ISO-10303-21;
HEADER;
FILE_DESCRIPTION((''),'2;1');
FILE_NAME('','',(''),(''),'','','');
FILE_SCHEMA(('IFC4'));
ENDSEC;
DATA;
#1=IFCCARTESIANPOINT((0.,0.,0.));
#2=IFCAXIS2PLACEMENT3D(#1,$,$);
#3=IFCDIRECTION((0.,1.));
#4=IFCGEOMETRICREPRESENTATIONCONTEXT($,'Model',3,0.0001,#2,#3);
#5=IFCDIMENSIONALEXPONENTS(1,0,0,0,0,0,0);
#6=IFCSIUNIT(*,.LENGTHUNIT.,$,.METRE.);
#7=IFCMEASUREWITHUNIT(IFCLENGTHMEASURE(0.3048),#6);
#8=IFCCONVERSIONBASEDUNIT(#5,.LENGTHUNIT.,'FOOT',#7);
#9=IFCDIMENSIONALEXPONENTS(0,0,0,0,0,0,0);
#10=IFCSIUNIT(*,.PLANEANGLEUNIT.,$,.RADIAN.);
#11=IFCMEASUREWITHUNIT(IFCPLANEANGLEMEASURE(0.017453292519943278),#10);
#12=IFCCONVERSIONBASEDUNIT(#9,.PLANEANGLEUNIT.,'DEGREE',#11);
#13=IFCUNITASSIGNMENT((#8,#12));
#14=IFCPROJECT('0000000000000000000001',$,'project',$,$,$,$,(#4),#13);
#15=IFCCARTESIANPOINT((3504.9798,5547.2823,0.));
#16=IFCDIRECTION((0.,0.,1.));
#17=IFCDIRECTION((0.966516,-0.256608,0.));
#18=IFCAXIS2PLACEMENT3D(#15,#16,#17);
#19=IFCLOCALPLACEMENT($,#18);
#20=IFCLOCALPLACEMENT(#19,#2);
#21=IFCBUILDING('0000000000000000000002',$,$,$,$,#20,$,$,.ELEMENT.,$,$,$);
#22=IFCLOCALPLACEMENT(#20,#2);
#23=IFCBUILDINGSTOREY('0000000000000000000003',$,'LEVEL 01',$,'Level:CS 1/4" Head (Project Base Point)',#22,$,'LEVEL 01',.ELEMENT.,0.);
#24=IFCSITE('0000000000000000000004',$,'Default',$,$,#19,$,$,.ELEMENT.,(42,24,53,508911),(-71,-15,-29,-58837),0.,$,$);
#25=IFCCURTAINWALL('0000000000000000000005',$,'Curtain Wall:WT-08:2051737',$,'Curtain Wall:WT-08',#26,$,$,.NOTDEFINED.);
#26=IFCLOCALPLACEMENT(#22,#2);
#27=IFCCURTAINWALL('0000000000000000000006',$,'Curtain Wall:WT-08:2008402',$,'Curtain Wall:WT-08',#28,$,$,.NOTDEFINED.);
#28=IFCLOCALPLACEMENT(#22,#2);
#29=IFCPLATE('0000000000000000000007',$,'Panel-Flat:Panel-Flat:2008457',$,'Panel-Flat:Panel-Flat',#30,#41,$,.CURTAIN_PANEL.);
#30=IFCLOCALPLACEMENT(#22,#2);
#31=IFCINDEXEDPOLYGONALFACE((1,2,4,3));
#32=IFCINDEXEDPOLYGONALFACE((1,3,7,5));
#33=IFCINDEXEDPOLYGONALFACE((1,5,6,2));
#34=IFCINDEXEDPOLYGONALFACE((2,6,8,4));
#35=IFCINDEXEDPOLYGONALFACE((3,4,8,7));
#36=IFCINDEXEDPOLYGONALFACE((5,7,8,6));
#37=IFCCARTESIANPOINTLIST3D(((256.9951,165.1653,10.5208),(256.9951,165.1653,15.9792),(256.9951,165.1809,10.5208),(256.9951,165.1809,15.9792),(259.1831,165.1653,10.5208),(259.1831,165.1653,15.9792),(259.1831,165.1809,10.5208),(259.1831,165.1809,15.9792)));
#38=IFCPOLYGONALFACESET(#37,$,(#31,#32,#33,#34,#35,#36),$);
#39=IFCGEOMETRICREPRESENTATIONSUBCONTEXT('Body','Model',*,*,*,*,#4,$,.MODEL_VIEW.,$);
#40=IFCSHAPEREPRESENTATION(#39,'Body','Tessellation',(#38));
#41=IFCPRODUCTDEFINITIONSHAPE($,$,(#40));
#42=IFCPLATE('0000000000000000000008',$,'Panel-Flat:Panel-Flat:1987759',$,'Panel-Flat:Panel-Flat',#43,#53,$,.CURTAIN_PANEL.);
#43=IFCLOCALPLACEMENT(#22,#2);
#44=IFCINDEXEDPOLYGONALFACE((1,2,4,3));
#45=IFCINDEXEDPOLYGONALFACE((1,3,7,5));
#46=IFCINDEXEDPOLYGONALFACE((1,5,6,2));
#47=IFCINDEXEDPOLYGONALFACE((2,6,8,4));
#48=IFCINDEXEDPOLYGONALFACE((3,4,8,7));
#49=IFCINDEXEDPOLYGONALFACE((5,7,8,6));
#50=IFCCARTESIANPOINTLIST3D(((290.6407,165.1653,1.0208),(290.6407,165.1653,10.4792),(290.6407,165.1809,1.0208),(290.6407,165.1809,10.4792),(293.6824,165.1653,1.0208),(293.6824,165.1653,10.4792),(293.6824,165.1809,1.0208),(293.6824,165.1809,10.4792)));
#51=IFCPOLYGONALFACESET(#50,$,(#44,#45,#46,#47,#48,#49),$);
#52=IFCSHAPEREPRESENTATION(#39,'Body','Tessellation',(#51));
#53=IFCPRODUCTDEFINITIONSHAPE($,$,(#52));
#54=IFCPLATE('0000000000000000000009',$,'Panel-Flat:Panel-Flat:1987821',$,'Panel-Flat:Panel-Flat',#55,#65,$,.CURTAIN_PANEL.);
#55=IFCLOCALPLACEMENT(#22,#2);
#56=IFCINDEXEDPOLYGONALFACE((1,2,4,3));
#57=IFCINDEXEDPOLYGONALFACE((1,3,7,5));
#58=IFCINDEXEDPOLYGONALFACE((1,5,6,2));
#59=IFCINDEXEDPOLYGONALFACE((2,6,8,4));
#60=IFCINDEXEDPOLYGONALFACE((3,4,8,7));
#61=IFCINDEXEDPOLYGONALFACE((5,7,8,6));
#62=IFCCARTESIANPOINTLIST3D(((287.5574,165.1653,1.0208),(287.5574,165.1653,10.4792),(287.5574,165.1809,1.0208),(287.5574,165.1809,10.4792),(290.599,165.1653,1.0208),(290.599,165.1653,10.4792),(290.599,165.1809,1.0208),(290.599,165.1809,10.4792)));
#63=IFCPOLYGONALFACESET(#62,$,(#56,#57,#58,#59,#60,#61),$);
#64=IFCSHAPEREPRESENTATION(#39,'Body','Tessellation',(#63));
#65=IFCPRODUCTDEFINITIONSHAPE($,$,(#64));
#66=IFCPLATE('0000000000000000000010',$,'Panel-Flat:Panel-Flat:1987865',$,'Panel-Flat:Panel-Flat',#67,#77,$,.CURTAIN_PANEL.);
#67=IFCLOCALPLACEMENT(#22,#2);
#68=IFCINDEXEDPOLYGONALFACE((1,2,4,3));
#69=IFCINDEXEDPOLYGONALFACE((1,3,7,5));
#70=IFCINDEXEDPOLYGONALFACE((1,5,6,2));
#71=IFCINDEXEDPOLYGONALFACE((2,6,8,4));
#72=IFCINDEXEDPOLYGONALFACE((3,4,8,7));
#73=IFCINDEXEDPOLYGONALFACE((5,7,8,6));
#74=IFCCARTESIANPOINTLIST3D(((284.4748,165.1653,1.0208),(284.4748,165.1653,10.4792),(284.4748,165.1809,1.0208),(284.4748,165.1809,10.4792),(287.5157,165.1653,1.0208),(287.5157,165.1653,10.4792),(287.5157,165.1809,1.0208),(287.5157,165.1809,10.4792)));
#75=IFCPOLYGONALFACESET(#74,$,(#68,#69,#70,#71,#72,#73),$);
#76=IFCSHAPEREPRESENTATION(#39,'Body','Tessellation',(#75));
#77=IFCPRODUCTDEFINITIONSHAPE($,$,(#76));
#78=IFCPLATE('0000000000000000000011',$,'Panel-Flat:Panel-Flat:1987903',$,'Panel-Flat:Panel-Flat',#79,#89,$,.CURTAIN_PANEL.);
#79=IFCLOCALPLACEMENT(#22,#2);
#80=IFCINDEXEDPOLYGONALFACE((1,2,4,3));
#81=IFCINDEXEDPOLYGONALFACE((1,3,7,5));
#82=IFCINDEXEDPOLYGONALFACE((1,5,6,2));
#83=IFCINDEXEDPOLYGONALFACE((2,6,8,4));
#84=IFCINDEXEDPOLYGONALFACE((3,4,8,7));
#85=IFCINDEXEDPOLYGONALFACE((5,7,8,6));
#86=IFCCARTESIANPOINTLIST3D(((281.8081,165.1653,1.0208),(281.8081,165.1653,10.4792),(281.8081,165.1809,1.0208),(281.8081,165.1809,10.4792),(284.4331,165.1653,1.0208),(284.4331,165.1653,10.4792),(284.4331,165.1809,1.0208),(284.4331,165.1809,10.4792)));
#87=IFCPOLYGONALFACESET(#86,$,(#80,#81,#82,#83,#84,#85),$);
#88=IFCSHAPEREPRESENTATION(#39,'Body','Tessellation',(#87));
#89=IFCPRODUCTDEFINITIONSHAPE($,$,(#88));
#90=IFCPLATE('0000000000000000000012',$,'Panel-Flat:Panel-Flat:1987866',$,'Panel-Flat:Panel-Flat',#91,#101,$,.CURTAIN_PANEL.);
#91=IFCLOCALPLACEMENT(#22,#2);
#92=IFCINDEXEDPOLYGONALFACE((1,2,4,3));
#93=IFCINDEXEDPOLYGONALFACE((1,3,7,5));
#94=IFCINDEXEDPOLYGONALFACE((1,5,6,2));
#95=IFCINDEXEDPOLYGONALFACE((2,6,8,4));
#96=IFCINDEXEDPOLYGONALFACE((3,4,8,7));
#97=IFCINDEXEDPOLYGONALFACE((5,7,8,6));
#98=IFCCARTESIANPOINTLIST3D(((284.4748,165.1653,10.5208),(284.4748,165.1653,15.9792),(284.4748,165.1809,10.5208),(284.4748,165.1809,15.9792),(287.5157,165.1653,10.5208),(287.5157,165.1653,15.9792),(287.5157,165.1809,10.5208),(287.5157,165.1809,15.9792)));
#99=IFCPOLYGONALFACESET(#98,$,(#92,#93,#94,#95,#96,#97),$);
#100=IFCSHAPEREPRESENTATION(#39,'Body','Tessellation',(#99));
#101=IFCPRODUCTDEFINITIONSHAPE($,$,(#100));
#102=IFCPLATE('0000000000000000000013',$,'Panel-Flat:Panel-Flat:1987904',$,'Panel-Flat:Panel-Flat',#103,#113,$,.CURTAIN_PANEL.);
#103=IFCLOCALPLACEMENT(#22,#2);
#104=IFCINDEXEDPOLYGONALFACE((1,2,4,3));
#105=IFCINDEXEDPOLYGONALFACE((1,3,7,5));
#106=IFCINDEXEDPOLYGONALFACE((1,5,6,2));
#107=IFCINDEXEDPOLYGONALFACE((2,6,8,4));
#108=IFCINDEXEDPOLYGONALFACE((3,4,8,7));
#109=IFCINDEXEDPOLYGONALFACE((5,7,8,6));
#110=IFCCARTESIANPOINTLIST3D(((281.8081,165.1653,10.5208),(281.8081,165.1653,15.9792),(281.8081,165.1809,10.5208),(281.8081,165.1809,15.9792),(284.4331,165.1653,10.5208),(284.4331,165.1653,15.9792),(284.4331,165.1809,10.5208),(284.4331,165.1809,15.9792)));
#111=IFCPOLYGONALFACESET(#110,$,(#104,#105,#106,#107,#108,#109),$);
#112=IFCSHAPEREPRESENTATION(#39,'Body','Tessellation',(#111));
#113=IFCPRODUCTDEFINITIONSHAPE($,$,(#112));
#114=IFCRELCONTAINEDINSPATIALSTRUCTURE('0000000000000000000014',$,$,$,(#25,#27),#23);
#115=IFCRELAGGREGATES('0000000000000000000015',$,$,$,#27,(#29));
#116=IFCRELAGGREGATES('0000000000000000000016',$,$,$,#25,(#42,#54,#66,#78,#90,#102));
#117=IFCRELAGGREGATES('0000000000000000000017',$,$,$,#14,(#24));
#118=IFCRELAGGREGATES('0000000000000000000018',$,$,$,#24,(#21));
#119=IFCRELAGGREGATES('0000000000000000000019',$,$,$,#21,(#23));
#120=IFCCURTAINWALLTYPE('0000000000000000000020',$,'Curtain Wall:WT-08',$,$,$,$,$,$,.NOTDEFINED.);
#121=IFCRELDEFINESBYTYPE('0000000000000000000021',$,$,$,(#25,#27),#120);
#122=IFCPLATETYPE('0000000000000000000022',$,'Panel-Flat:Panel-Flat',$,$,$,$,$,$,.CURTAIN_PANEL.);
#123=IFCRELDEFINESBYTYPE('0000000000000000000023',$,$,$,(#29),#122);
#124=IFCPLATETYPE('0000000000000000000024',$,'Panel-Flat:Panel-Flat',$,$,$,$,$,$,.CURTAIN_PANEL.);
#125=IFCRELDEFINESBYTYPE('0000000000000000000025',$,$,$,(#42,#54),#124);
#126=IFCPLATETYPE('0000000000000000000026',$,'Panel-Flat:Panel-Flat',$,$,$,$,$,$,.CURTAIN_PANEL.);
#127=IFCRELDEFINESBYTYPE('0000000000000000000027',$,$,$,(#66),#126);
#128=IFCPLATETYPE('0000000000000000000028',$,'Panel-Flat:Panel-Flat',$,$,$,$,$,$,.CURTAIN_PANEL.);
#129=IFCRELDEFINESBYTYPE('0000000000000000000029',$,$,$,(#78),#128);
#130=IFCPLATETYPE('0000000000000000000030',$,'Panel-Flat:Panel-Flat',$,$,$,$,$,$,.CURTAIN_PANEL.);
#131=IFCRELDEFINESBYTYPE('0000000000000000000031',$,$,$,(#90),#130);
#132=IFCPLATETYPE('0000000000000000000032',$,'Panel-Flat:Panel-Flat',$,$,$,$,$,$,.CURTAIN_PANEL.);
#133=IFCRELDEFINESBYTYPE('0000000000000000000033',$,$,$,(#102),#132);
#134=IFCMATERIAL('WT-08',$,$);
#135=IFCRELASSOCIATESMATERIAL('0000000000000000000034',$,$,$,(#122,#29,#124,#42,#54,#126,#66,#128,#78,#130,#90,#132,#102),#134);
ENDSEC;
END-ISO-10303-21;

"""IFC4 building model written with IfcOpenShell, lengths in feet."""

from ifc_helpers import new_model, entity, si_unit, converted_unit, direction, frame, origin, place, context, subcontext, project, spatial, indexed_curve, outline, extrude, source, transform, mapped, material, type_object, type_shapes, element, aggregate, save


model = new_model("IFC4")

# Units and contexts
model_context = context("Model", 3, precision=0.0001, world=origin(), true_north=direction((0.0, 1.0)))
body_context = subcontext(model_context, "Body", "Model", "MODEL_VIEW")
ifc_project = project(units=[converted_unit("LENGTHUNIT", "FOOT", entity("IfcLengthMeasure", 0.3048), si_unit("LENGTHUNIT", "METRE"), dimensions=[1, 0, 0, 0, 0, 0, 0]), converted_unit("PLANEANGLEUNIT", "DEGREE", entity("IfcPlaneAngleMeasure", 0.017453292519943278), si_unit("PLANEANGLEUNIT", "RADIAN"), dimensions=[0, 0, 0, 0, 0, 0, 0])], contexts=[model_context])

# Site, building, storey
site_placement = place(None, frame((3504.9798, 5547.2823, 0.0), z_axis=(0.0, 0.0, 1.0), x_axis=(0.966516, -0.256608, 0.0)))
site = spatial("IfcSite", under=ifc_project, at=site_placement, Name="Default", CompositionType="ELEMENT", RefLatitude=(42, 24, 53, 508911), RefLongitude=(-71, -15, -29, -58837), RefElevation=0.0)
building_placement = place(site_placement, origin())
building = spatial("IfcBuilding", under=site, at=building_placement, CompositionType="ELEMENT")
storey_placement = place(building_placement, origin())
storey = spatial("IfcBuildingStorey", under=building, at=storey_placement, Name="LEVEL 01", ObjectType="Level:CS 1/4\" Head (Project Base Point)", LongName="LEVEL 01", CompositionType="ELEMENT", Elevation=0.0)

# Curtain wall
curtain_wall_type_1 = type_object("IfcCurtainWallType", Name="Curtain Wall:WT-08", PredefinedType="NOTDEFINED")
curtain_wall_1_placement = place(storey_placement, origin())
curtain_wall_1 = element("IfcCurtainWall", 1, at=curtain_wall_1_placement, inside=storey, type_object=curtain_wall_type_1, Name="Curtain Wall:WT-08:2051737", ObjectType="Curtain Wall:WT-08", PredefinedType="NOTDEFINED")
ifc_material_1 = material(Name="WT-08")

# Curtain wall, plate
curtain_wall_2_placement = place(storey_placement, origin())
curtain_wall_2 = element("IfcCurtainWall", 2, at=curtain_wall_2_placement, inside=storey, type_object=curtain_wall_type_1, Name="Curtain Wall:WT-08:2008402", ObjectType="Curtain Wall:WT-08", PredefinedType="NOTDEFINED")
plate_type_1 = type_object("IfcPlateType", Name="Panel-Flat:Panel-Flat", PredefinedType="CURTAIN_PANEL", material=ifc_material_1)
shared_shape_1 = source(origin(), body_context, "Body", "SweptSolid", [
    extrude(outline(indexed_curve([(-0.0078, -1.094), (0.0078, -1.094), (0.0078, 1.094), (-0.0078, 1.094), (-0.0078, -1.094)], self_intersect=False)), frame((0.0, -0.0078, 0.0208), z_axis=(0.0, 0.0, 1.0), x_axis=(0.0, -1.0, 0.0)), (0.0, 0.0, 1.0), 5.4583),
])
type_shapes(plate_type_1, [shared_shape_1])
plate_1_placement = place(curtain_wall_2_placement, frame((258.0891, 165.1653, 10.5), z_axis=(0.0, 0.0, 1.0), x_axis=(-1.0, 0.0, 0.0)))
plate_1 = element("IfcPlate", 3, at=plate_1_placement, type_object=plate_type_1, material=ifc_material_1, Name="Panel-Flat:Panel-Flat:2008457", ObjectType="Panel-Flat:Panel-Flat", PredefinedType="CURTAIN_PANEL", context=body_context, shape_type="MappedRepresentation", body=[
    mapped(shared_shape_1, transform((0.0, 0.0, 0.0), scale=1.0)),
])
aggregate(curtain_wall_2, [plate_1])

# Plates
plate_type_2 = type_object("IfcPlateType", Name="Panel-Flat:Panel-Flat", PredefinedType="CURTAIN_PANEL", material=ifc_material_1)
shared_shape_2 = source(origin(), body_context, "Body", "SweptSolid", [
    extrude(outline(indexed_curve([(-0.0078, -1.5208), (0.0078, -1.5208), (0.0078, 1.5208), (-0.0078, 1.5208), (-0.0078, -1.5208)], self_intersect=False)), frame((0.0, -0.0078, 0.0208), z_axis=(0.0, 0.0, 1.0), x_axis=(0.0, -1.0, 0.0)), (0.0, 0.0, 1.0), 9.4583),
])
type_shapes(plate_type_2, [shared_shape_2])
plate_2_placement = place(curtain_wall_1_placement, frame((292.1615, 165.1653, 1.0), z_axis=(0.0, 0.0, 1.0), x_axis=(-1.0, 0.0, 0.0)))
plate_2 = element("IfcPlate", 4, at=plate_2_placement, type_object=plate_type_2, material=ifc_material_1, Name="Panel-Flat:Panel-Flat:1987759", ObjectType="Panel-Flat:Panel-Flat", PredefinedType="CURTAIN_PANEL", context=body_context, shape_type="MappedRepresentation", body=[
    mapped(shared_shape_2, transform((0.0, 0.0, 0.0), scale=1.0)),
])
plate_3_placement = place(curtain_wall_1_placement, frame((289.0782, 165.1653, 1.0), z_axis=(0.0, 0.0, 1.0), x_axis=(-1.0, 0.0, 0.0)))
plate_3 = element("IfcPlate", 5, at=plate_3_placement, type_object=plate_type_2, material=ifc_material_1, Name="Panel-Flat:Panel-Flat:1987821", ObjectType="Panel-Flat:Panel-Flat", PredefinedType="CURTAIN_PANEL", context=body_context, shape_type="MappedRepresentation", body=[
    mapped(shared_shape_2, transform((0.0, 0.0, 0.0), scale=1.0)),
])
plate_type_3 = type_object("IfcPlateType", Name="Panel-Flat:Panel-Flat", PredefinedType="CURTAIN_PANEL", material=ifc_material_1)
shared_shape_3 = source(origin(), body_context, "Body", "SweptSolid", [
    extrude(outline(indexed_curve([(-0.0078, -1.5205), (0.0078, -1.5205), (0.0078, 1.5205), (-0.0078, 1.5205), (-0.0078, -1.5205)], self_intersect=False)), frame((0.0, -0.0078, 0.0208), z_axis=(0.0, 0.0, 1.0), x_axis=(0.0, -1.0, 0.0)), (0.0, 0.0, 1.0), 9.4583),
])
type_shapes(plate_type_3, [shared_shape_3])
plate_4_placement = place(curtain_wall_1_placement, frame((285.9952, 165.1653, 1.0), z_axis=(0.0, 0.0, 1.0), x_axis=(-1.0, 0.0, 0.0)))
plate_4 = element("IfcPlate", 6, at=plate_4_placement, type_object=plate_type_3, material=ifc_material_1, Name="Panel-Flat:Panel-Flat:1987865", ObjectType="Panel-Flat:Panel-Flat", PredefinedType="CURTAIN_PANEL", context=body_context, shape_type="MappedRepresentation", body=[
    mapped(shared_shape_3, transform((0.0, 0.0, 0.0), scale=1.0)),
])
plate_type_4 = type_object("IfcPlateType", Name="Panel-Flat:Panel-Flat", PredefinedType="CURTAIN_PANEL", material=ifc_material_1)
shared_shape_4 = source(origin(), body_context, "Body", "SweptSolid", [
    extrude(outline(indexed_curve([(-0.0078, -1.3125), (0.0078, -1.3125), (0.0078, 1.3125), (-0.0078, 1.3125), (-0.0078, -1.3125)], self_intersect=False)), frame((0.0, -0.0078, 0.0208), z_axis=(0.0, 0.0, 1.0), x_axis=(0.0, -1.0, 0.0)), (0.0, 0.0, 1.0), 9.4583),
])
type_shapes(plate_type_4, [shared_shape_4])
plate_5_placement = place(curtain_wall_1_placement, frame((283.1206, 165.1653, 1.0), z_axis=(0.0, 0.0, 1.0), x_axis=(-1.0, 0.0, 0.0)))
plate_5 = element("IfcPlate", 7, at=plate_5_placement, type_object=plate_type_4, material=ifc_material_1, Name="Panel-Flat:Panel-Flat:1987903", ObjectType="Panel-Flat:Panel-Flat", PredefinedType="CURTAIN_PANEL", context=body_context, shape_type="MappedRepresentation", body=[
    mapped(shared_shape_4, transform((0.0, 0.0, 0.0), scale=1.0)),
])
plate_type_5 = type_object("IfcPlateType", Name="Panel-Flat:Panel-Flat", PredefinedType="CURTAIN_PANEL", material=ifc_material_1)
shared_shape_5 = source(origin(), body_context, "Body", "SweptSolid", [
    extrude(outline(indexed_curve([(-0.0078, -1.5205), (0.0078, -1.5205), (0.0078, 1.5205), (-0.0078, 1.5205), (-0.0078, -1.5205)], self_intersect=False)), frame((0.0, -0.0078, 0.0208), z_axis=(0.0, 0.0, 1.0), x_axis=(0.0, -1.0, 0.0)), (0.0, 0.0, 1.0), 5.4583),
])
type_shapes(plate_type_5, [shared_shape_5])
plate_6_placement = place(curtain_wall_1_placement, frame((285.9952, 165.1653, 10.5), z_axis=(0.0, 0.0, 1.0), x_axis=(-1.0, 0.0, 0.0)))
plate_6 = element("IfcPlate", 8, at=plate_6_placement, type_object=plate_type_5, material=ifc_material_1, Name="Panel-Flat:Panel-Flat:1987866", ObjectType="Panel-Flat:Panel-Flat", PredefinedType="CURTAIN_PANEL", context=body_context, shape_type="MappedRepresentation", body=[
    mapped(shared_shape_5, transform((0.0, 0.0, 0.0), scale=1.0)),
])
plate_type_6 = type_object("IfcPlateType", Name="Panel-Flat:Panel-Flat", PredefinedType="CURTAIN_PANEL", material=ifc_material_1)
shared_shape_6 = source(origin(), body_context, "Body", "SweptSolid", [
    extrude(outline(indexed_curve([(-0.0078, -1.3125), (0.0078, -1.3125), (0.0078, 1.3125), (-0.0078, 1.3125), (-0.0078, -1.3125)], self_intersect=False)), frame((0.0, -0.0078, 0.0208), z_axis=(0.0, 0.0, 1.0), x_axis=(0.0, -1.0, 0.0)), (0.0, 0.0, 1.0), 5.4583),
])
type_shapes(plate_type_6, [shared_shape_6])
plate_7_placement = place(curtain_wall_1_placement, frame((283.1206, 165.1653, 10.5), z_axis=(0.0, 0.0, 1.0), x_axis=(-1.0, 0.0, 0.0)))
plate_7 = element("IfcPlate", 9, at=plate_7_placement, type_object=plate_type_6, material=ifc_material_1, Name="Panel-Flat:Panel-Flat:1987904", ObjectType="Panel-Flat:Panel-Flat", PredefinedType="CURTAIN_PANEL", context=body_context, shape_type="MappedRepresentation", body=[
    mapped(shared_shape_6, transform((0.0, 0.0, 0.0), scale=1.0)),
])
aggregate(curtain_wall_1, [plate_2, plate_3, plate_4, plate_5, plate_6, plate_7])

save(model, "model.ifc")
